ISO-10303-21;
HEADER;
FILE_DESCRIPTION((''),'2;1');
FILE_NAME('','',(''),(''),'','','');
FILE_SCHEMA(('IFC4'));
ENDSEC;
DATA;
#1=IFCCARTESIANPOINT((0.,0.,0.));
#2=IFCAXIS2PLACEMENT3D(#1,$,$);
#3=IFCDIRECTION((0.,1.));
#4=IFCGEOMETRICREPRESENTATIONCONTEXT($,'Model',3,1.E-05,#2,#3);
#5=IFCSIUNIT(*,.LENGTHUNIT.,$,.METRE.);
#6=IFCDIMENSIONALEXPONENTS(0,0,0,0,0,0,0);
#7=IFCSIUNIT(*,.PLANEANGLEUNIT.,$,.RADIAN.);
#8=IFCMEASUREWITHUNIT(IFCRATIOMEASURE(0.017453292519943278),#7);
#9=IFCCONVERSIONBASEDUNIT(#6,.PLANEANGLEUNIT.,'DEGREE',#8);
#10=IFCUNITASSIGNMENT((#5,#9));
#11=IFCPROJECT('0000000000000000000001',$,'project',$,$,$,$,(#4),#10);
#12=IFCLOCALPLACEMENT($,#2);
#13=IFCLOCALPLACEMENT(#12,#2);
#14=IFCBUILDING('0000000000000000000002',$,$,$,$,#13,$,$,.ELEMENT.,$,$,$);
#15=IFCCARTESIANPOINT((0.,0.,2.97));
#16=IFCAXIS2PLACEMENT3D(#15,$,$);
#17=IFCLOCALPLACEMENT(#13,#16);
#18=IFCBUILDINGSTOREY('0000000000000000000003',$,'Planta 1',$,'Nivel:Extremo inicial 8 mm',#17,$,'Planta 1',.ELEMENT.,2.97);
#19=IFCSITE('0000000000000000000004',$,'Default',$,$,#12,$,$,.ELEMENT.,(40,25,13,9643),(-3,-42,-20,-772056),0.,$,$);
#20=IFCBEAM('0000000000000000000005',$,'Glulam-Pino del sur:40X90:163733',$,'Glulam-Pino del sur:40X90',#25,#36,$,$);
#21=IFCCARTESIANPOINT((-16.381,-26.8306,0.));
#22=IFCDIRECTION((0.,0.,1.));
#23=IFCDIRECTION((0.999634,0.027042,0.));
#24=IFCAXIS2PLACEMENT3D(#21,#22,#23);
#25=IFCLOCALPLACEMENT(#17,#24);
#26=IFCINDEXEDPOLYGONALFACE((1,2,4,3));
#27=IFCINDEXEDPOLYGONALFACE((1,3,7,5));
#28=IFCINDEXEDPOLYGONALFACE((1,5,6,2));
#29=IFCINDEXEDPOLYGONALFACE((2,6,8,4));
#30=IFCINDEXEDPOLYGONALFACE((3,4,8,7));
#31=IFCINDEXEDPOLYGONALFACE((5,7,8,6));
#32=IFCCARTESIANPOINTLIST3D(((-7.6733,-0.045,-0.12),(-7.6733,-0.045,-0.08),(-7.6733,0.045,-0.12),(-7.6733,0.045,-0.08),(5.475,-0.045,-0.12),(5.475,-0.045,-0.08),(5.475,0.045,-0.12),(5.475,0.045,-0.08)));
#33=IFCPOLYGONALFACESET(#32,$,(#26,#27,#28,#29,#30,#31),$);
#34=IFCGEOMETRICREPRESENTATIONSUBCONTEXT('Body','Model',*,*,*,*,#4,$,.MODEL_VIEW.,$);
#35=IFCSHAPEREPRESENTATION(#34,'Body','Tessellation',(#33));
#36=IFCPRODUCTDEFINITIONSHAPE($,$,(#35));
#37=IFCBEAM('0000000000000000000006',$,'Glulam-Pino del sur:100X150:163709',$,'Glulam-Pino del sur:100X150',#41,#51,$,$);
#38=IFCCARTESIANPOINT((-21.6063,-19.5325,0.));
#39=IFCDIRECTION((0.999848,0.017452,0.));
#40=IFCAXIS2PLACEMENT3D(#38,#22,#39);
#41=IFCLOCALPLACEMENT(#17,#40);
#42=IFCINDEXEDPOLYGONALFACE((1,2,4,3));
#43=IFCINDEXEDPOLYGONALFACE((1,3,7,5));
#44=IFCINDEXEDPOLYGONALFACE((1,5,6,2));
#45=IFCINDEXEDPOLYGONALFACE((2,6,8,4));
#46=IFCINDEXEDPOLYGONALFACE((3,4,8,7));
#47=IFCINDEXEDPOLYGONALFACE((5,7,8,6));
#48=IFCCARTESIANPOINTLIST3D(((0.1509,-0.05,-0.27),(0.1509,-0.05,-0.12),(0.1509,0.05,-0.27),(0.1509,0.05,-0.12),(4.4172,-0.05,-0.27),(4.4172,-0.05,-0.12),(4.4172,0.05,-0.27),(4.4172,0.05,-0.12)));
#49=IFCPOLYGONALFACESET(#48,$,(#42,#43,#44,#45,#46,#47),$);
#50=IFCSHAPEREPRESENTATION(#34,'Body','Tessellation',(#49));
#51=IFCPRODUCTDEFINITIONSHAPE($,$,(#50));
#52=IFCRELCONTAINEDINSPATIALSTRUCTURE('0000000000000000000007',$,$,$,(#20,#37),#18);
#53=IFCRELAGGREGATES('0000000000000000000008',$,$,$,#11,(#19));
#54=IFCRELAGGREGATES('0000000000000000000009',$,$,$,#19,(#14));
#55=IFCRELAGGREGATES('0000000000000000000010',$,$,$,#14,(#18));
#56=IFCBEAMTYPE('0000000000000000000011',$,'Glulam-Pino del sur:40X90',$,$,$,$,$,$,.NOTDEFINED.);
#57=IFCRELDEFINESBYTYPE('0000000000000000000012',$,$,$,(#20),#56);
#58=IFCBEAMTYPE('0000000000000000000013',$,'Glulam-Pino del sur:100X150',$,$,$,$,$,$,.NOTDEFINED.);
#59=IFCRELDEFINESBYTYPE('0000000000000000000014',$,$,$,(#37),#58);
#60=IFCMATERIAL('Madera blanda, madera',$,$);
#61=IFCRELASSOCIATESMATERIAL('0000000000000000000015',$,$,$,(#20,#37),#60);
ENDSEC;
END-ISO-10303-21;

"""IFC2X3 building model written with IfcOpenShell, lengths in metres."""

from ifc_helpers import new_model, entity, si_unit, converted_unit, direction, frame, frame_2d, origin, origin_2d_with_axis, place, context, subcontext, project, spatial, rectangle, extrude, material, type_object, element, save


model = new_model("IFC2X3")

# Units and contexts
model_context = context("Model", 3, precision=1e-05, world=origin(), true_north=direction((0.0, 1.0)))
body_context = subcontext(model_context, "Body", "Model", "MODEL_VIEW")
ifc_project = project(units=[si_unit("LENGTHUNIT", "METRE"), converted_unit("PLANEANGLEUNIT", "DEGREE", entity("IfcRatioMeasure", 0.017453292519943278), si_unit("PLANEANGLEUNIT", "RADIAN"), dimensions=[0, 0, 0, 0, 0, 0, 0])], contexts=[model_context])

# Site, building, storey
site_placement = place(None, origin())
site = spatial("IfcSite", under=ifc_project, at=site_placement, Name="Default", CompositionType="ELEMENT", RefLatitude=(40, 25, 13, 9643), RefLongitude=(-3, -42, -20, -772056), RefElevation=0.0)
building_placement = place(site_placement, origin())
building = spatial("IfcBuilding", under=site, at=building_placement, CompositionType="ELEMENT")
storey_placement = place(building_placement, frame((0.0, 0.0, 2.97)))
storey = spatial("IfcBuildingStorey", under=building, at=storey_placement, Name="Planta 1", ObjectType="Nivel:Extremo inicial 8 mm", LongName="Planta 1", CompositionType="ELEMENT", Elevation=2.97)

# Beams
ifc_material_1 = material(Name="Madera blanda, madera")
beam_type_1 = type_object("IfcBeamType", Name="Glulam-Pino del sur:40X90", PredefinedType="NOTDEFINED")
beam_1_placement = place(storey_placement, frame((-16.381, -26.8306, 0.0), z_axis=(0.0, 0.0, 1.0), x_axis=(0.999634, 0.027042, 0.0)))
element("IfcBeam", 1, at=beam_1_placement, inside=storey, type_object=beam_type_1, material=ifc_material_1, Name="Glulam-Pino del sur:40X90:163733", ObjectType="Glulam-Pino del sur:40X90", context=body_context, shape_type="SweptSolid", body=[
    extrude(rectangle(XDim=0.04, YDim=0.09, at=origin_2d_with_axis()), frame((-7.6733, 0.0, -0.1), z_axis=(1.0, 0.0, 0.0), x_axis=(0.0, 0.0, -1.0)), (0.0, 0.0, 1.0), 13.1483),
])
beam_type_2 = type_object("IfcBeamType", Name="Glulam-Pino del sur:100X150", PredefinedType="NOTDEFINED")
beam_2_placement = place(storey_placement, frame((-21.6063, -19.5325, 0.0), z_axis=(0.0, 0.0, 1.0), x_axis=(0.999848, 0.017452, 0.0)))
element("IfcBeam", 2, at=beam_2_placement, inside=storey, type_object=beam_type_2, material=ifc_material_1, Name="Glulam-Pino del sur:100X150:163709", ObjectType="Glulam-Pino del sur:100X150", context=body_context, shape_type="SweptSolid", body=[
    extrude(rectangle(XDim=0.15, YDim=0.1, at=frame_2d((0.0, 0.0), x_axis=(1.0, 0.0))), frame((0.1509, 0.0, -0.195), z_axis=(1.0, 0.0, 0.0), x_axis=(0.0, 0.0, -1.0)), (0.0, 0.0, 1.0), 4.2663),
])

save(model, "model.ifc")
